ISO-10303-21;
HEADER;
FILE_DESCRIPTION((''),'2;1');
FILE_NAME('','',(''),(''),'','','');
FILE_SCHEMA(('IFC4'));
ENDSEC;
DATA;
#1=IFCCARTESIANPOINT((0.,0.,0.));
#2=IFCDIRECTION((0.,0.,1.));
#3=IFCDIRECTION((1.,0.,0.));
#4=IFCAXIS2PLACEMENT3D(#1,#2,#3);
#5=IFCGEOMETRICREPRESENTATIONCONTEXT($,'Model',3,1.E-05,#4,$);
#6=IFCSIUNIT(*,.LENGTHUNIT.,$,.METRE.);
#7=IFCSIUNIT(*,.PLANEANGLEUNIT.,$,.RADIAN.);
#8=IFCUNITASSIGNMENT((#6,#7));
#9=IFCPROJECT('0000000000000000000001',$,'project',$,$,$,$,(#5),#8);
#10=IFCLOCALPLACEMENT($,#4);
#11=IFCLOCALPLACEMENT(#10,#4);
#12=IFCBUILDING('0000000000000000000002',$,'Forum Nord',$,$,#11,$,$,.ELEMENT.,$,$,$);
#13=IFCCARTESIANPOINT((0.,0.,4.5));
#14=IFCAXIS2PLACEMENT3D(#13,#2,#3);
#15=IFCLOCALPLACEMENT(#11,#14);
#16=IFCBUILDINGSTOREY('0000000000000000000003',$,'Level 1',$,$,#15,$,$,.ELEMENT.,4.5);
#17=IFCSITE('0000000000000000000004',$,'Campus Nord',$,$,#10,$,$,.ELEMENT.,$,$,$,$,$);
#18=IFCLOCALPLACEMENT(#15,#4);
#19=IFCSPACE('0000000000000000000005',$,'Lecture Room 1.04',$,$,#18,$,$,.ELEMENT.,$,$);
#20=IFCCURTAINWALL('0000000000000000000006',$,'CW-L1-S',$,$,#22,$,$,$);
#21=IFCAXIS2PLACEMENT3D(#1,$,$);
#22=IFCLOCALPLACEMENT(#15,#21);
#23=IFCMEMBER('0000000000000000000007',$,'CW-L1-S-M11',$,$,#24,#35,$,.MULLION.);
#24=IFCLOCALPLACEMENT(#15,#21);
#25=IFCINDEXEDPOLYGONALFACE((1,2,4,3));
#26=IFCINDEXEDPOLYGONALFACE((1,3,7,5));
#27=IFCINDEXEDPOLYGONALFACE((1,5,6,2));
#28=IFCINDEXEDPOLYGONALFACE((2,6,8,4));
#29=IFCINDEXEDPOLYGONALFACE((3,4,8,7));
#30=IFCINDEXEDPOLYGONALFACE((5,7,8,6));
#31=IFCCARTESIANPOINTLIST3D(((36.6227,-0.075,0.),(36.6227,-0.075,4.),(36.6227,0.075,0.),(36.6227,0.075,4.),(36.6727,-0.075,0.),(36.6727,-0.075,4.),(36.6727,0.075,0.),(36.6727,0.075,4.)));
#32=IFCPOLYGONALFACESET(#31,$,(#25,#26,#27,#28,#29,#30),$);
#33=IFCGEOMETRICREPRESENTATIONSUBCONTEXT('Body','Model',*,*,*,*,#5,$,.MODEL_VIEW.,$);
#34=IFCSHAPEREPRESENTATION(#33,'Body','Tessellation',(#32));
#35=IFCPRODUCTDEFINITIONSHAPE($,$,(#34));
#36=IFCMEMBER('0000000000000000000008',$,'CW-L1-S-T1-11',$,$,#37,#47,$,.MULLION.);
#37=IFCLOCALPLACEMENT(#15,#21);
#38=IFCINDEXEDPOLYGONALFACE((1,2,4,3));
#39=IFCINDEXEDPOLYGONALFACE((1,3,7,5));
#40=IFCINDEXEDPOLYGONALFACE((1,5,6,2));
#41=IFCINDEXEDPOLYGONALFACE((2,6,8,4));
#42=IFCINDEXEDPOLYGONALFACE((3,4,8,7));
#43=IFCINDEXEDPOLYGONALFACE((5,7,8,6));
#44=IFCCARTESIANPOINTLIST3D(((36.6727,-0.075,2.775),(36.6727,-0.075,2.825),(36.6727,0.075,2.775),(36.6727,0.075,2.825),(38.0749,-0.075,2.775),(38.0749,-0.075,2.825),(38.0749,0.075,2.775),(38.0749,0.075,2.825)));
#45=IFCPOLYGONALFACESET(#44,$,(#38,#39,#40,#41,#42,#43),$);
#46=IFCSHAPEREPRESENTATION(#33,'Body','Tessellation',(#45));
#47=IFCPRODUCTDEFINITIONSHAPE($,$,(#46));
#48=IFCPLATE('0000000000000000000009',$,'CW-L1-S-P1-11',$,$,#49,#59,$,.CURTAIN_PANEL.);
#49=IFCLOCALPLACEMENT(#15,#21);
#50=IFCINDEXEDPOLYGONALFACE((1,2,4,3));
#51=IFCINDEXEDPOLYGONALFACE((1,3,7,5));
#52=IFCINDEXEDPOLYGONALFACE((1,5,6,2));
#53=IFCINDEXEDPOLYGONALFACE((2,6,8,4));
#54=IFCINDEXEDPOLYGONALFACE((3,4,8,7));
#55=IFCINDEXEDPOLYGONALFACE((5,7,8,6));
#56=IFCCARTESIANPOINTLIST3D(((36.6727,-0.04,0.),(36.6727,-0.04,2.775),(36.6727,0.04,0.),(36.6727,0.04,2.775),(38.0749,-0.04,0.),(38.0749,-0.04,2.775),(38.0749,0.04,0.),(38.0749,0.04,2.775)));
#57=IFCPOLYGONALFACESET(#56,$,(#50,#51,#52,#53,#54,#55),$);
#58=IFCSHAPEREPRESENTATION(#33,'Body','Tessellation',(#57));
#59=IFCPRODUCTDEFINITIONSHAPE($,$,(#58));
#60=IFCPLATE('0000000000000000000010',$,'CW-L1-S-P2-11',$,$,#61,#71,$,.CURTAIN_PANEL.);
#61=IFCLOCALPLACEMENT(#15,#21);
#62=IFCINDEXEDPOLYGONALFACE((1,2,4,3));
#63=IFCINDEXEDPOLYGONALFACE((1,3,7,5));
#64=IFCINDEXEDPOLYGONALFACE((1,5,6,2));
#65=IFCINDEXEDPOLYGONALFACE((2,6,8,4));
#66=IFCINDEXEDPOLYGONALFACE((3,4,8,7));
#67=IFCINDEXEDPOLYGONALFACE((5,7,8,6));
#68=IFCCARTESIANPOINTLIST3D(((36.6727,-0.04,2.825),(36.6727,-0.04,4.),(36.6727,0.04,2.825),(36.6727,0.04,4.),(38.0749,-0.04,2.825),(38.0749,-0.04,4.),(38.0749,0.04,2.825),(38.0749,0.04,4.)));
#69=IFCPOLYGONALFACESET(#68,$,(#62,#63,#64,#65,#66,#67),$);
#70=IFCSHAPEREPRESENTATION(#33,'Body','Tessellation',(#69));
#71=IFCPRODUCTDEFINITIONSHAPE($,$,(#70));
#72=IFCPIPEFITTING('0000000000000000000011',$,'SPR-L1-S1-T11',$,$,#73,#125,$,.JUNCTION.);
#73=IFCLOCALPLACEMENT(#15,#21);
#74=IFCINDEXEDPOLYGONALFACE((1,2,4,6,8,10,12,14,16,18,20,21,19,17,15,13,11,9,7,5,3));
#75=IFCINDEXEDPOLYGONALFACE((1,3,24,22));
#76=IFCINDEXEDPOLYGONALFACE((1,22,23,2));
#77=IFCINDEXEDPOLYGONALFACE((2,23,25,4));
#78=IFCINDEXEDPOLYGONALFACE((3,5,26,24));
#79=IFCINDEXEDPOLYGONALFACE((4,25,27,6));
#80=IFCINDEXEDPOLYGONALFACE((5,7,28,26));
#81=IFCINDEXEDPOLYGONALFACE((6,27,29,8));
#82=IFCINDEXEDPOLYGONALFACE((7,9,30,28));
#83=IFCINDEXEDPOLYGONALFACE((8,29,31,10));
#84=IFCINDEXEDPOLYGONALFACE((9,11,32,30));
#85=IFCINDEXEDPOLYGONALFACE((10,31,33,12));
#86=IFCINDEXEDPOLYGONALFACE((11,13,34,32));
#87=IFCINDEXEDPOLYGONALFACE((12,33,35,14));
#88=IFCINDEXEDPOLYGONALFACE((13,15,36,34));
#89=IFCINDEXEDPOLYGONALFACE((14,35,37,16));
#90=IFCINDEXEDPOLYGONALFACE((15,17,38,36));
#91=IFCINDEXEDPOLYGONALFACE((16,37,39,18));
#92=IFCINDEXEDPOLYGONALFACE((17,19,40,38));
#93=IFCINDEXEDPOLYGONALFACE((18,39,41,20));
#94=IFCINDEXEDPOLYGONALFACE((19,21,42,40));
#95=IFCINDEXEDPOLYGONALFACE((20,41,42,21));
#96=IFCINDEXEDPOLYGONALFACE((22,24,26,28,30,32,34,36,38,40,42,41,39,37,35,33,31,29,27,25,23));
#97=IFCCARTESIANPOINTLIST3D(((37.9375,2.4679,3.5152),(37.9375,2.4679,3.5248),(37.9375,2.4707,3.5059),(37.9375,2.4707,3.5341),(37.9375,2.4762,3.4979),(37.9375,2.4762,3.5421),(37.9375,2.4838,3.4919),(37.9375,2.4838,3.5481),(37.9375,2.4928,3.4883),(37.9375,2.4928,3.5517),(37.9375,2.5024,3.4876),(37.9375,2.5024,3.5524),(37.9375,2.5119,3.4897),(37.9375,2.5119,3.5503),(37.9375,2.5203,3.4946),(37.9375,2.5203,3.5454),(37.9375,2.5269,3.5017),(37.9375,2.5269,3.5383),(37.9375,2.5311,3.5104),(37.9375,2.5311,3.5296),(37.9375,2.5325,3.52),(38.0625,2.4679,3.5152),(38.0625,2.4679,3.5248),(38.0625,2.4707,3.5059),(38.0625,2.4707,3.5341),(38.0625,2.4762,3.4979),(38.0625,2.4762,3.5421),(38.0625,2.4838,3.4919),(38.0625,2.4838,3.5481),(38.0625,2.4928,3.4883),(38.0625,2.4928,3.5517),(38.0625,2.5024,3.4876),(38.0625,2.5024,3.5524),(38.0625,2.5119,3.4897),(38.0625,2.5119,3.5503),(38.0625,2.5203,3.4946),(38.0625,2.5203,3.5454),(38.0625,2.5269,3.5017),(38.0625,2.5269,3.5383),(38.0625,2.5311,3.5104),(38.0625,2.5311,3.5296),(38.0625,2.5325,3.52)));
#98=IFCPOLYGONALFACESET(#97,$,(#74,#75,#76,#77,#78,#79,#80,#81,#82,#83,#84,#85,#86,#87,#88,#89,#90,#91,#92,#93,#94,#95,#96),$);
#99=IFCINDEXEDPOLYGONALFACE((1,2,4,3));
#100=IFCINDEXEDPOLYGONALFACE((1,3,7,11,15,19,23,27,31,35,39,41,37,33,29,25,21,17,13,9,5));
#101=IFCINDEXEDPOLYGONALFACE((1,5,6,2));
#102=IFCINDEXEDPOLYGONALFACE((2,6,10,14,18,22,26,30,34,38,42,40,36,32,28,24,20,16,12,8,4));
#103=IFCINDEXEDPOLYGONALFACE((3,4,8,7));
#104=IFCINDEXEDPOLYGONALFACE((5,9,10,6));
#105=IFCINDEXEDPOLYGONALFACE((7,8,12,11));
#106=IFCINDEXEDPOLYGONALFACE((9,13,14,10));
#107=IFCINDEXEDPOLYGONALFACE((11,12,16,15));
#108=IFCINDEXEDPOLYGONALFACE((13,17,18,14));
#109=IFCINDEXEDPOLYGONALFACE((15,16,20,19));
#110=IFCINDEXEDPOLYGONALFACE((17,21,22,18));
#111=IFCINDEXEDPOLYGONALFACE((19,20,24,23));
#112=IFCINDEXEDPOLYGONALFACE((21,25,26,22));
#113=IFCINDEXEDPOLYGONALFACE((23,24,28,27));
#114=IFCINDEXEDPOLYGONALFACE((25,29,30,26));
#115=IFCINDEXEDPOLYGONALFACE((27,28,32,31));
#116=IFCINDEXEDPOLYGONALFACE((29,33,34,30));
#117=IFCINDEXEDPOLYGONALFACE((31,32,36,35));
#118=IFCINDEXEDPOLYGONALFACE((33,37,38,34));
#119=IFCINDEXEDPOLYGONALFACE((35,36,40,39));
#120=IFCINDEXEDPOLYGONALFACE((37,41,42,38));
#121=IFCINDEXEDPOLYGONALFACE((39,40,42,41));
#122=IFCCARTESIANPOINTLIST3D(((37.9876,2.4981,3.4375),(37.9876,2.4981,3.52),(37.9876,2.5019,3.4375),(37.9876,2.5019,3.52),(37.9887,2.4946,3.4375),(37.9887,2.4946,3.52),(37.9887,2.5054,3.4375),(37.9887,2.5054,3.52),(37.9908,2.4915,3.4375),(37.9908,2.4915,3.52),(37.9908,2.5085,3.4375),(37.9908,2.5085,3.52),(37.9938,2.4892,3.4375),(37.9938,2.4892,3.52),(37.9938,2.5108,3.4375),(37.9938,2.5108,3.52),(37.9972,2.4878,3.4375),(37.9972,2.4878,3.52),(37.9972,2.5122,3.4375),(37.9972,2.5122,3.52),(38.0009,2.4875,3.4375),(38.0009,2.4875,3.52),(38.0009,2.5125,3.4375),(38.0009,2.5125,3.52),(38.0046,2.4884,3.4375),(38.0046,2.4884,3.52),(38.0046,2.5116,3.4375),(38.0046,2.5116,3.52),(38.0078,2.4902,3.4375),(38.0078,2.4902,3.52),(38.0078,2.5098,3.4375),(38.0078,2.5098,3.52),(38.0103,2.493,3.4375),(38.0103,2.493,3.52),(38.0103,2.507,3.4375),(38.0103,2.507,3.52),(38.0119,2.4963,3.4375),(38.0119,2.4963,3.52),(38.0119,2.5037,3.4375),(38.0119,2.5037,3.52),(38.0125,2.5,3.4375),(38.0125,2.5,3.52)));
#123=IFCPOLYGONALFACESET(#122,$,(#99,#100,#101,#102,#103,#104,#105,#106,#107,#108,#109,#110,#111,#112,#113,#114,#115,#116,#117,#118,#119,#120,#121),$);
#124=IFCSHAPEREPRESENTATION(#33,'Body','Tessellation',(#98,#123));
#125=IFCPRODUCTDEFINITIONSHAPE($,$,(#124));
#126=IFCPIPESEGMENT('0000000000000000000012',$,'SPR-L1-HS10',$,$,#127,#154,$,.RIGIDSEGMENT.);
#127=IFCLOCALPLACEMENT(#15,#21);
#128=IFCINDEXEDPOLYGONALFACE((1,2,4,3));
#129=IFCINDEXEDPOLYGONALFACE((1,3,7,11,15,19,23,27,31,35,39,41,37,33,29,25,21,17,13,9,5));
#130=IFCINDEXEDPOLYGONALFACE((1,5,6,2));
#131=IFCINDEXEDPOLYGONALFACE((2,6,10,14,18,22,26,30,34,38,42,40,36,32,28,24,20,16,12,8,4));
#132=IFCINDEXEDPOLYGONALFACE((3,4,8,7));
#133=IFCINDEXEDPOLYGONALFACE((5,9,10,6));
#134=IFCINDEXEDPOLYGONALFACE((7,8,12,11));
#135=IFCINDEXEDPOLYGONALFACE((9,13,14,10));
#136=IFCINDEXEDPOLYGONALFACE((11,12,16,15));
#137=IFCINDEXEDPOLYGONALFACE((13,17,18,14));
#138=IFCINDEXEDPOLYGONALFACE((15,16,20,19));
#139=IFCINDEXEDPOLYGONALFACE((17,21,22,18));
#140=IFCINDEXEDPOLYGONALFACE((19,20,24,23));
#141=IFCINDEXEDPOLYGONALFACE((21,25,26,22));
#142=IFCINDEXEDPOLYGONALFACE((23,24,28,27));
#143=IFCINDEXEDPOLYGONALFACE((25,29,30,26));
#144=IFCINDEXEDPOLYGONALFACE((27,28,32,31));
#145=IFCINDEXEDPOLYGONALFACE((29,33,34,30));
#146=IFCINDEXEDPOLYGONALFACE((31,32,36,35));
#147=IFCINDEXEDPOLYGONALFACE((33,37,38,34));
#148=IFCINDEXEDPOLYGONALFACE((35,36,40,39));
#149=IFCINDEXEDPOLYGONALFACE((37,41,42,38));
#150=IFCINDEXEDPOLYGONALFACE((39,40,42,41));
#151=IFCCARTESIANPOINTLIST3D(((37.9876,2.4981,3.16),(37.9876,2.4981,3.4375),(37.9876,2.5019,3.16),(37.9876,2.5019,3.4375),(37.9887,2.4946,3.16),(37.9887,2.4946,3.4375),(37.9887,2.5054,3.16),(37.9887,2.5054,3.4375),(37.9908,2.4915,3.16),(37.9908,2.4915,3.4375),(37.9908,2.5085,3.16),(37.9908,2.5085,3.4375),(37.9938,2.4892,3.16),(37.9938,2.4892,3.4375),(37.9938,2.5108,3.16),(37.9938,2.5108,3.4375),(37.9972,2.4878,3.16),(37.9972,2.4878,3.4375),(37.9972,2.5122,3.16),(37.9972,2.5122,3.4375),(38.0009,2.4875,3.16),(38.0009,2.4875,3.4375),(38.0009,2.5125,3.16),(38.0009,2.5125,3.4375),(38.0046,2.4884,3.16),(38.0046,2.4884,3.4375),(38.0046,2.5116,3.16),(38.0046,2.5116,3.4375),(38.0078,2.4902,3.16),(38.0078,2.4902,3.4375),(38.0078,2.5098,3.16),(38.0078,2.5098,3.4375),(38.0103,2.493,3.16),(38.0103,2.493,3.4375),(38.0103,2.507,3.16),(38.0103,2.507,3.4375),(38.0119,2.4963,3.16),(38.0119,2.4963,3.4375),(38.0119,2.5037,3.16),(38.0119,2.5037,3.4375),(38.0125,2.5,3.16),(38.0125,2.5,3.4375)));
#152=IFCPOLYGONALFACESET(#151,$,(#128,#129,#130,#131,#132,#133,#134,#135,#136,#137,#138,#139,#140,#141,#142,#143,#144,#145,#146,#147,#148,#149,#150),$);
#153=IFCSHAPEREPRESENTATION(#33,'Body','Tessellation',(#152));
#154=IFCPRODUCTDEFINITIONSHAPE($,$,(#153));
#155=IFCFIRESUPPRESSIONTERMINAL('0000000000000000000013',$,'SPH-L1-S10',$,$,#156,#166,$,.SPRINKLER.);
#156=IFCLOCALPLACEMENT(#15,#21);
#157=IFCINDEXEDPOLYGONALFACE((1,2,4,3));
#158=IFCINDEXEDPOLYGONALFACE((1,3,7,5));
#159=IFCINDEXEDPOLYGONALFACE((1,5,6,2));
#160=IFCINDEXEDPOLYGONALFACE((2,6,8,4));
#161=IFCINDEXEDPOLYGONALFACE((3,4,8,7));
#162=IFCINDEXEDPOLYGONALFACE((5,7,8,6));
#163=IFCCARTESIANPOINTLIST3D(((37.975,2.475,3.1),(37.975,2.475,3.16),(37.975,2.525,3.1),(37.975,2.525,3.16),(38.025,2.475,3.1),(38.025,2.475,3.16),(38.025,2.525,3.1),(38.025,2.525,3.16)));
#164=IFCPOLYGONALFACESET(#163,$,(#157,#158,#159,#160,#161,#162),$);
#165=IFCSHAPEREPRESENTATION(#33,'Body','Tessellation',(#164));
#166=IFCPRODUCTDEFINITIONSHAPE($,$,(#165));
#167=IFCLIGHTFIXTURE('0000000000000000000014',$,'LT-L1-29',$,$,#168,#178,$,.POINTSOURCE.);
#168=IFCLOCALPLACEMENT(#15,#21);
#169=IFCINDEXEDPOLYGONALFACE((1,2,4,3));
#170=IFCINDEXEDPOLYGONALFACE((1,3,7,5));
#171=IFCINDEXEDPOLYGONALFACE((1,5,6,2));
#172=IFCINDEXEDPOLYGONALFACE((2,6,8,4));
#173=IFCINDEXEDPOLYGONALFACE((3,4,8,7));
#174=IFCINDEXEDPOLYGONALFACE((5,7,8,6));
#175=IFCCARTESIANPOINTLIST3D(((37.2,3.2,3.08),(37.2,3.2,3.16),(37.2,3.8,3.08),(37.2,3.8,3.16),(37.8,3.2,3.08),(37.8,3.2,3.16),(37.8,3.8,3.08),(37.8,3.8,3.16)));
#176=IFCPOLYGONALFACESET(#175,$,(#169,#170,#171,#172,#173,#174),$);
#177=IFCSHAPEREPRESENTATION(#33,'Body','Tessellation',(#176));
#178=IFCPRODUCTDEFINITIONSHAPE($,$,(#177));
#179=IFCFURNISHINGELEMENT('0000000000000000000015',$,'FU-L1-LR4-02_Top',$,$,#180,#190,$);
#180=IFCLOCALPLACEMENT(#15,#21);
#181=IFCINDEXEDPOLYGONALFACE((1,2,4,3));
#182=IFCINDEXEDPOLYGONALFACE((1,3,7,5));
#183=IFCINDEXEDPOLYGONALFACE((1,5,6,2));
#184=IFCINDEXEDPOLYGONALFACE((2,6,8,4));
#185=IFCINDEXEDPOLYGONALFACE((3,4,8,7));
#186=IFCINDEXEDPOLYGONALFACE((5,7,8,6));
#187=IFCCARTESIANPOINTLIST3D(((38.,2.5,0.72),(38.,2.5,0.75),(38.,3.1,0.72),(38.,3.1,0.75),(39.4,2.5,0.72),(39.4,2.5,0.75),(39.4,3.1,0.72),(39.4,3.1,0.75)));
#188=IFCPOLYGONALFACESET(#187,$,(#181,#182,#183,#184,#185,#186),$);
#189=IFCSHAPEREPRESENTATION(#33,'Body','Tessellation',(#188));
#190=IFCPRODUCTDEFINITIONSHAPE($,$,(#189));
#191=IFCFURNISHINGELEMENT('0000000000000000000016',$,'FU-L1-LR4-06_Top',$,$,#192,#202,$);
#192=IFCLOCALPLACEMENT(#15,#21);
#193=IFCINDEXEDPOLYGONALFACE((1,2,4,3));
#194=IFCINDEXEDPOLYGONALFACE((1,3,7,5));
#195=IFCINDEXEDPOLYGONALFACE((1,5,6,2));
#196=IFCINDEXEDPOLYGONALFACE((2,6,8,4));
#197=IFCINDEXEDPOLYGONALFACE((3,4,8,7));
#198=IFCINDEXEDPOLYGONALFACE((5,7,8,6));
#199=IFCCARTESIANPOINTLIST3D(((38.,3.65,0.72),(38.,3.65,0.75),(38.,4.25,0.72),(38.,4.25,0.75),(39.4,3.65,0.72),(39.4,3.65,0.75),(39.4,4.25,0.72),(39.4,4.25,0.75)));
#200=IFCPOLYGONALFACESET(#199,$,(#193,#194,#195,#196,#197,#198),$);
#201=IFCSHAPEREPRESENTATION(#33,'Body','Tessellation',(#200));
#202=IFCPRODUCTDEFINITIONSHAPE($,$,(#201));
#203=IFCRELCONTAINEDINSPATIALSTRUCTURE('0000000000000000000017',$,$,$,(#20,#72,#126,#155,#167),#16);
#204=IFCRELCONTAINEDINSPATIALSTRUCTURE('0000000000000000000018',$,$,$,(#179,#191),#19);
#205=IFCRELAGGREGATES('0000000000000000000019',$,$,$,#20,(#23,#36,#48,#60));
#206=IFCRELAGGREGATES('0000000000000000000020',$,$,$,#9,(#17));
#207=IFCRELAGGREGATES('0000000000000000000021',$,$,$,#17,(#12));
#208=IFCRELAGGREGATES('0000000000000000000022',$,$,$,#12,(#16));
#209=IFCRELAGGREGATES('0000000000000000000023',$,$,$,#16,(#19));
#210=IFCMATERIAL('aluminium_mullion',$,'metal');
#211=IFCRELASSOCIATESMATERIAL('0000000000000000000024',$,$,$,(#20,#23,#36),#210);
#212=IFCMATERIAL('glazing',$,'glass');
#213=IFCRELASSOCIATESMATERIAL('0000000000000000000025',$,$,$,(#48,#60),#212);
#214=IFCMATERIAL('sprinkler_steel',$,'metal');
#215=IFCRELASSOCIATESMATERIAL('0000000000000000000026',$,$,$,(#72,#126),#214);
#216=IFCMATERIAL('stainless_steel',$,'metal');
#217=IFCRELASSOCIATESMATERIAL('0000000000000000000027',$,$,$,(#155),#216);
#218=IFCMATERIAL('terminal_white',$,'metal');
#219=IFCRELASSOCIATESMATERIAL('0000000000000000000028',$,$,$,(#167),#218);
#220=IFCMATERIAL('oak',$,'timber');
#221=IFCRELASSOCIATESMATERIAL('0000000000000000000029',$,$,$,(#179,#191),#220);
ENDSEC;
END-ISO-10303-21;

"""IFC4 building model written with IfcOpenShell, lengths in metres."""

from ifc_helpers import new_model, si_unit, frame, frame_2d, origin_with_axes, origin_2d_with_axis, place, context, subcontext, project, spatial, rectangle, circle, extrude, material, element, aggregate, save


model = new_model("IFC4")

# Units and contexts
model_context = context("Model", 3, precision=1e-05, world=origin_with_axes())
body_context = subcontext(model_context, "Body", "Model", "MODEL_VIEW")
ifc_project = project(units=[si_unit("LENGTHUNIT", "METRE"), si_unit("PLANEANGLEUNIT", "RADIAN")], contexts=[model_context])

# Site, building, storey
site_placement = place(None, origin_with_axes())
site = spatial("IfcSite", under=ifc_project, at=site_placement, Name="Campus Nord", CompositionType="ELEMENT")
building_placement = place(site_placement, origin_with_axes())
building = spatial("IfcBuilding", under=site, at=building_placement, Name="Forum Nord", CompositionType="ELEMENT")
storey_placement = place(building_placement, frame((0.0, 0.0, 4.5), z_axis=(0.0, 0.0, 1.0), x_axis=(1.0, 0.0, 0.0)))
storey = spatial("IfcBuildingStorey", under=building, at=storey_placement, Name="Level 1", CompositionType="ELEMENT", Elevation=4.5)

# Curtain wall, members, plates
ifc_material_1 = material(Name="aluminium_mullion", Category="metal")
curtain_wall_placement = place(storey_placement, origin_with_axes())
curtain_wall = element("IfcCurtainWall", 1, at=curtain_wall_placement, inside=storey, material=ifc_material_1, Name="CW-L1-S")
member_1_placement = place(storey_placement, frame((36.6477, 0.0, 0.0), z_axis=(0.0, 0.0, 1.0), x_axis=(1.0, 0.0, 0.0)))
member_1 = element("IfcMember", 2, at=member_1_placement, material=ifc_material_1, Name="CW-L1-S-M11", PredefinedType="MULLION", context=body_context, shape_type="SweptSolid", body=[
    extrude(rectangle(XDim=0.05, YDim=0.15, at=origin_2d_with_axis()), origin_with_axes(), (0.0, 0.0, 1.0), 4.0),
])
member_2_placement = place(storey_placement, frame((36.6727, 0.0, 2.8), z_axis=(1.0, 0.0, 0.0), x_axis=(0.0, 1.0, 0.0)))
member_2 = element("IfcMember", 3, at=member_2_placement, material=ifc_material_1, Name="CW-L1-S-T1-11", PredefinedType="MULLION", context=body_context, shape_type="SweptSolid", body=[
    extrude(rectangle(XDim=0.15, YDim=0.05, at=origin_2d_with_axis()), origin_with_axes(), (0.0, 0.0, 1.0), 1.4023),
])
ifc_material_2 = material(Name="glazing", Category="glass")
plate_1_placement = place(storey_placement, frame((36.6727, 0.0, 0.0), z_axis=(0.0, 0.0, 1.0), x_axis=(1.0, 0.0, 0.0)))
plate_1 = element("IfcPlate", 4, at=plate_1_placement, material=ifc_material_2, Name="CW-L1-S-P1-11", PredefinedType="CURTAIN_PANEL", context=body_context, shape_type="SweptSolid", body=[
    extrude(rectangle(XDim=1.4023, YDim=0.08, at=frame_2d((0.7011, 0.0), x_axis=(1.0, 0.0))), origin_with_axes(), (0.0, 0.0, 1.0), 2.775),
])
plate_2_placement = place(storey_placement, frame((36.6727, 0.0, 2.825), z_axis=(0.0, 0.0, 1.0), x_axis=(1.0, 0.0, 0.0)))
plate_2 = element("IfcPlate", 5, at=plate_2_placement, material=ifc_material_2, Name="CW-L1-S-P2-11", PredefinedType="CURTAIN_PANEL", context=body_context, shape_type="SweptSolid", body=[
    extrude(rectangle(XDim=1.4023, YDim=0.08, at=frame_2d((0.7011, 0.0), x_axis=(1.0, 0.0))), origin_with_axes(), (0.0, 0.0, 1.0), 1.175),
])
aggregate(curtain_wall, [member_1, member_2, plate_1, plate_2])

# Pipe fitting
ifc_material_3 = material(Name="sprinkler_steel", Category="metal")
pipe_fitting_placement = place(storey_placement, frame((37.9375, 2.5, 3.52), z_axis=(1.0, 0.0, 0.0), x_axis=(0.0, 1.0, 0.0)))
element("IfcPipeFitting", 6, at=pipe_fitting_placement, inside=storey, material=ifc_material_3, Name="SPR-L1-S1-T11", PredefinedType="JUNCTION", context=body_context, shape_type="SweptSolid", body=[
    extrude(circle(Radius=0.0325, at=origin_2d_with_axis()), origin_with_axes(), (0.0, 0.0, 1.0), 0.125),
    extrude(circle(Radius=0.0125, at=origin_2d_with_axis()), frame((0.0, 0.0, 0.0625), z_axis=(0.0, -1.0, 0.0), x_axis=(0.0, 0.0, 1.0)), (0.0, 0.0, 1.0), 0.0825),
])

# Pipe segment
pipe_segment_placement = place(storey_placement, frame((38.0, 2.5, 3.4375), z_axis=(0.0, 0.0, -1.0), x_axis=(1.0, 0.0, 0.0)))
element("IfcPipeSegment", 7, at=pipe_segment_placement, inside=storey, material=ifc_material_3, Name="SPR-L1-HS10", PredefinedType="RIGIDSEGMENT", context=body_context, shape_type="SweptSolid", body=[
    extrude(circle(Radius=0.0125, at=origin_2d_with_axis()), origin_with_axes(), (0.0, 0.0, 1.0), 0.2775),
])

# Fire suppression terminal
ifc_material_4 = material(Name="stainless_steel", Category="metal")
fire_suppression_terminal_placement = place(storey_placement, frame((38.0, 2.5, 3.1), z_axis=(0.0, 0.0, 1.0), x_axis=(1.0, 0.0, 0.0)))
element("IfcFireSuppressionTerminal", 8, at=fire_suppression_terminal_placement, inside=storey, material=ifc_material_4, Name="SPH-L1-S10", PredefinedType="SPRINKLER", context=body_context, shape_type="SweptSolid", body=[
    extrude(rectangle(XDim=0.05, YDim=0.05, at=origin_2d_with_axis()), origin_with_axes(), (0.0, 0.0, 1.0), 0.06),
])

# Light fixture
ifc_material_5 = material(Name="terminal_white", Category="metal")
light_fixture_placement = place(storey_placement, frame((37.5, 3.5, 3.08), z_axis=(0.0, 0.0, 1.0), x_axis=(1.0, 0.0, 0.0)))
element("IfcLightFixture", 9, at=light_fixture_placement, inside=storey, material=ifc_material_5, Name="LT-L1-29", PredefinedType="POINTSOURCE", context=body_context, shape_type="SweptSolid", body=[
    extrude(rectangle(XDim=0.6, YDim=0.6, at=origin_2d_with_axis()), origin_with_axes(), (0.0, 0.0, 1.0), 0.08),
])

# Shared definitions
space_placement = place(storey_placement, origin_with_axes())
space = spatial("IfcSpace", under=storey, at=space_placement, Name="Lecture Room 1.04", CompositionType="ELEMENT")

# Furnishing elements
ifc_material_6 = material(Name="oak", Category="timber")
furnishing_1_placement = place(storey_placement, frame((38.0, 2.5, 0.0), z_axis=(0.0, 0.0, 1.0), x_axis=(1.0, 0.0, 0.0)))
element("IfcFurnishingElement", 10, at=furnishing_1_placement, inside=space, material=ifc_material_6, Name="FU-L1-LR4-02_Top", context=body_context, shape_type="SweptSolid", body=[
    extrude(rectangle(XDim=1.4, YDim=0.6, at=frame_2d((0.7, 0.3), x_axis=(1.0, 0.0))), frame((0.0, 0.0, 0.72), z_axis=(0.0, 0.0, 1.0), x_axis=(1.0, 0.0, 0.0)), (0.0, 0.0, 1.0), 0.03),
])
furnishing_2_placement = place(storey_placement, frame((38.0, 3.65, 0.0), z_axis=(0.0, 0.0, 1.0), x_axis=(1.0, 0.0, 0.0)))
element("IfcFurnishingElement", 11, at=furnishing_2_placement, inside=space, material=ifc_material_6, Name="FU-L1-LR4-06_Top", context=body_context, shape_type="SweptSolid", body=[
    extrude(rectangle(XDim=1.4, YDim=0.6, at=frame_2d((0.7, 0.3), x_axis=(1.0, 0.0))), frame((0.0, 0.0, 0.72), z_axis=(0.0, 0.0, 1.0), x_axis=(1.0, 0.0, 0.0)), (0.0, 0.0, 1.0), 0.03),
])

save(model, "model.ifc")
